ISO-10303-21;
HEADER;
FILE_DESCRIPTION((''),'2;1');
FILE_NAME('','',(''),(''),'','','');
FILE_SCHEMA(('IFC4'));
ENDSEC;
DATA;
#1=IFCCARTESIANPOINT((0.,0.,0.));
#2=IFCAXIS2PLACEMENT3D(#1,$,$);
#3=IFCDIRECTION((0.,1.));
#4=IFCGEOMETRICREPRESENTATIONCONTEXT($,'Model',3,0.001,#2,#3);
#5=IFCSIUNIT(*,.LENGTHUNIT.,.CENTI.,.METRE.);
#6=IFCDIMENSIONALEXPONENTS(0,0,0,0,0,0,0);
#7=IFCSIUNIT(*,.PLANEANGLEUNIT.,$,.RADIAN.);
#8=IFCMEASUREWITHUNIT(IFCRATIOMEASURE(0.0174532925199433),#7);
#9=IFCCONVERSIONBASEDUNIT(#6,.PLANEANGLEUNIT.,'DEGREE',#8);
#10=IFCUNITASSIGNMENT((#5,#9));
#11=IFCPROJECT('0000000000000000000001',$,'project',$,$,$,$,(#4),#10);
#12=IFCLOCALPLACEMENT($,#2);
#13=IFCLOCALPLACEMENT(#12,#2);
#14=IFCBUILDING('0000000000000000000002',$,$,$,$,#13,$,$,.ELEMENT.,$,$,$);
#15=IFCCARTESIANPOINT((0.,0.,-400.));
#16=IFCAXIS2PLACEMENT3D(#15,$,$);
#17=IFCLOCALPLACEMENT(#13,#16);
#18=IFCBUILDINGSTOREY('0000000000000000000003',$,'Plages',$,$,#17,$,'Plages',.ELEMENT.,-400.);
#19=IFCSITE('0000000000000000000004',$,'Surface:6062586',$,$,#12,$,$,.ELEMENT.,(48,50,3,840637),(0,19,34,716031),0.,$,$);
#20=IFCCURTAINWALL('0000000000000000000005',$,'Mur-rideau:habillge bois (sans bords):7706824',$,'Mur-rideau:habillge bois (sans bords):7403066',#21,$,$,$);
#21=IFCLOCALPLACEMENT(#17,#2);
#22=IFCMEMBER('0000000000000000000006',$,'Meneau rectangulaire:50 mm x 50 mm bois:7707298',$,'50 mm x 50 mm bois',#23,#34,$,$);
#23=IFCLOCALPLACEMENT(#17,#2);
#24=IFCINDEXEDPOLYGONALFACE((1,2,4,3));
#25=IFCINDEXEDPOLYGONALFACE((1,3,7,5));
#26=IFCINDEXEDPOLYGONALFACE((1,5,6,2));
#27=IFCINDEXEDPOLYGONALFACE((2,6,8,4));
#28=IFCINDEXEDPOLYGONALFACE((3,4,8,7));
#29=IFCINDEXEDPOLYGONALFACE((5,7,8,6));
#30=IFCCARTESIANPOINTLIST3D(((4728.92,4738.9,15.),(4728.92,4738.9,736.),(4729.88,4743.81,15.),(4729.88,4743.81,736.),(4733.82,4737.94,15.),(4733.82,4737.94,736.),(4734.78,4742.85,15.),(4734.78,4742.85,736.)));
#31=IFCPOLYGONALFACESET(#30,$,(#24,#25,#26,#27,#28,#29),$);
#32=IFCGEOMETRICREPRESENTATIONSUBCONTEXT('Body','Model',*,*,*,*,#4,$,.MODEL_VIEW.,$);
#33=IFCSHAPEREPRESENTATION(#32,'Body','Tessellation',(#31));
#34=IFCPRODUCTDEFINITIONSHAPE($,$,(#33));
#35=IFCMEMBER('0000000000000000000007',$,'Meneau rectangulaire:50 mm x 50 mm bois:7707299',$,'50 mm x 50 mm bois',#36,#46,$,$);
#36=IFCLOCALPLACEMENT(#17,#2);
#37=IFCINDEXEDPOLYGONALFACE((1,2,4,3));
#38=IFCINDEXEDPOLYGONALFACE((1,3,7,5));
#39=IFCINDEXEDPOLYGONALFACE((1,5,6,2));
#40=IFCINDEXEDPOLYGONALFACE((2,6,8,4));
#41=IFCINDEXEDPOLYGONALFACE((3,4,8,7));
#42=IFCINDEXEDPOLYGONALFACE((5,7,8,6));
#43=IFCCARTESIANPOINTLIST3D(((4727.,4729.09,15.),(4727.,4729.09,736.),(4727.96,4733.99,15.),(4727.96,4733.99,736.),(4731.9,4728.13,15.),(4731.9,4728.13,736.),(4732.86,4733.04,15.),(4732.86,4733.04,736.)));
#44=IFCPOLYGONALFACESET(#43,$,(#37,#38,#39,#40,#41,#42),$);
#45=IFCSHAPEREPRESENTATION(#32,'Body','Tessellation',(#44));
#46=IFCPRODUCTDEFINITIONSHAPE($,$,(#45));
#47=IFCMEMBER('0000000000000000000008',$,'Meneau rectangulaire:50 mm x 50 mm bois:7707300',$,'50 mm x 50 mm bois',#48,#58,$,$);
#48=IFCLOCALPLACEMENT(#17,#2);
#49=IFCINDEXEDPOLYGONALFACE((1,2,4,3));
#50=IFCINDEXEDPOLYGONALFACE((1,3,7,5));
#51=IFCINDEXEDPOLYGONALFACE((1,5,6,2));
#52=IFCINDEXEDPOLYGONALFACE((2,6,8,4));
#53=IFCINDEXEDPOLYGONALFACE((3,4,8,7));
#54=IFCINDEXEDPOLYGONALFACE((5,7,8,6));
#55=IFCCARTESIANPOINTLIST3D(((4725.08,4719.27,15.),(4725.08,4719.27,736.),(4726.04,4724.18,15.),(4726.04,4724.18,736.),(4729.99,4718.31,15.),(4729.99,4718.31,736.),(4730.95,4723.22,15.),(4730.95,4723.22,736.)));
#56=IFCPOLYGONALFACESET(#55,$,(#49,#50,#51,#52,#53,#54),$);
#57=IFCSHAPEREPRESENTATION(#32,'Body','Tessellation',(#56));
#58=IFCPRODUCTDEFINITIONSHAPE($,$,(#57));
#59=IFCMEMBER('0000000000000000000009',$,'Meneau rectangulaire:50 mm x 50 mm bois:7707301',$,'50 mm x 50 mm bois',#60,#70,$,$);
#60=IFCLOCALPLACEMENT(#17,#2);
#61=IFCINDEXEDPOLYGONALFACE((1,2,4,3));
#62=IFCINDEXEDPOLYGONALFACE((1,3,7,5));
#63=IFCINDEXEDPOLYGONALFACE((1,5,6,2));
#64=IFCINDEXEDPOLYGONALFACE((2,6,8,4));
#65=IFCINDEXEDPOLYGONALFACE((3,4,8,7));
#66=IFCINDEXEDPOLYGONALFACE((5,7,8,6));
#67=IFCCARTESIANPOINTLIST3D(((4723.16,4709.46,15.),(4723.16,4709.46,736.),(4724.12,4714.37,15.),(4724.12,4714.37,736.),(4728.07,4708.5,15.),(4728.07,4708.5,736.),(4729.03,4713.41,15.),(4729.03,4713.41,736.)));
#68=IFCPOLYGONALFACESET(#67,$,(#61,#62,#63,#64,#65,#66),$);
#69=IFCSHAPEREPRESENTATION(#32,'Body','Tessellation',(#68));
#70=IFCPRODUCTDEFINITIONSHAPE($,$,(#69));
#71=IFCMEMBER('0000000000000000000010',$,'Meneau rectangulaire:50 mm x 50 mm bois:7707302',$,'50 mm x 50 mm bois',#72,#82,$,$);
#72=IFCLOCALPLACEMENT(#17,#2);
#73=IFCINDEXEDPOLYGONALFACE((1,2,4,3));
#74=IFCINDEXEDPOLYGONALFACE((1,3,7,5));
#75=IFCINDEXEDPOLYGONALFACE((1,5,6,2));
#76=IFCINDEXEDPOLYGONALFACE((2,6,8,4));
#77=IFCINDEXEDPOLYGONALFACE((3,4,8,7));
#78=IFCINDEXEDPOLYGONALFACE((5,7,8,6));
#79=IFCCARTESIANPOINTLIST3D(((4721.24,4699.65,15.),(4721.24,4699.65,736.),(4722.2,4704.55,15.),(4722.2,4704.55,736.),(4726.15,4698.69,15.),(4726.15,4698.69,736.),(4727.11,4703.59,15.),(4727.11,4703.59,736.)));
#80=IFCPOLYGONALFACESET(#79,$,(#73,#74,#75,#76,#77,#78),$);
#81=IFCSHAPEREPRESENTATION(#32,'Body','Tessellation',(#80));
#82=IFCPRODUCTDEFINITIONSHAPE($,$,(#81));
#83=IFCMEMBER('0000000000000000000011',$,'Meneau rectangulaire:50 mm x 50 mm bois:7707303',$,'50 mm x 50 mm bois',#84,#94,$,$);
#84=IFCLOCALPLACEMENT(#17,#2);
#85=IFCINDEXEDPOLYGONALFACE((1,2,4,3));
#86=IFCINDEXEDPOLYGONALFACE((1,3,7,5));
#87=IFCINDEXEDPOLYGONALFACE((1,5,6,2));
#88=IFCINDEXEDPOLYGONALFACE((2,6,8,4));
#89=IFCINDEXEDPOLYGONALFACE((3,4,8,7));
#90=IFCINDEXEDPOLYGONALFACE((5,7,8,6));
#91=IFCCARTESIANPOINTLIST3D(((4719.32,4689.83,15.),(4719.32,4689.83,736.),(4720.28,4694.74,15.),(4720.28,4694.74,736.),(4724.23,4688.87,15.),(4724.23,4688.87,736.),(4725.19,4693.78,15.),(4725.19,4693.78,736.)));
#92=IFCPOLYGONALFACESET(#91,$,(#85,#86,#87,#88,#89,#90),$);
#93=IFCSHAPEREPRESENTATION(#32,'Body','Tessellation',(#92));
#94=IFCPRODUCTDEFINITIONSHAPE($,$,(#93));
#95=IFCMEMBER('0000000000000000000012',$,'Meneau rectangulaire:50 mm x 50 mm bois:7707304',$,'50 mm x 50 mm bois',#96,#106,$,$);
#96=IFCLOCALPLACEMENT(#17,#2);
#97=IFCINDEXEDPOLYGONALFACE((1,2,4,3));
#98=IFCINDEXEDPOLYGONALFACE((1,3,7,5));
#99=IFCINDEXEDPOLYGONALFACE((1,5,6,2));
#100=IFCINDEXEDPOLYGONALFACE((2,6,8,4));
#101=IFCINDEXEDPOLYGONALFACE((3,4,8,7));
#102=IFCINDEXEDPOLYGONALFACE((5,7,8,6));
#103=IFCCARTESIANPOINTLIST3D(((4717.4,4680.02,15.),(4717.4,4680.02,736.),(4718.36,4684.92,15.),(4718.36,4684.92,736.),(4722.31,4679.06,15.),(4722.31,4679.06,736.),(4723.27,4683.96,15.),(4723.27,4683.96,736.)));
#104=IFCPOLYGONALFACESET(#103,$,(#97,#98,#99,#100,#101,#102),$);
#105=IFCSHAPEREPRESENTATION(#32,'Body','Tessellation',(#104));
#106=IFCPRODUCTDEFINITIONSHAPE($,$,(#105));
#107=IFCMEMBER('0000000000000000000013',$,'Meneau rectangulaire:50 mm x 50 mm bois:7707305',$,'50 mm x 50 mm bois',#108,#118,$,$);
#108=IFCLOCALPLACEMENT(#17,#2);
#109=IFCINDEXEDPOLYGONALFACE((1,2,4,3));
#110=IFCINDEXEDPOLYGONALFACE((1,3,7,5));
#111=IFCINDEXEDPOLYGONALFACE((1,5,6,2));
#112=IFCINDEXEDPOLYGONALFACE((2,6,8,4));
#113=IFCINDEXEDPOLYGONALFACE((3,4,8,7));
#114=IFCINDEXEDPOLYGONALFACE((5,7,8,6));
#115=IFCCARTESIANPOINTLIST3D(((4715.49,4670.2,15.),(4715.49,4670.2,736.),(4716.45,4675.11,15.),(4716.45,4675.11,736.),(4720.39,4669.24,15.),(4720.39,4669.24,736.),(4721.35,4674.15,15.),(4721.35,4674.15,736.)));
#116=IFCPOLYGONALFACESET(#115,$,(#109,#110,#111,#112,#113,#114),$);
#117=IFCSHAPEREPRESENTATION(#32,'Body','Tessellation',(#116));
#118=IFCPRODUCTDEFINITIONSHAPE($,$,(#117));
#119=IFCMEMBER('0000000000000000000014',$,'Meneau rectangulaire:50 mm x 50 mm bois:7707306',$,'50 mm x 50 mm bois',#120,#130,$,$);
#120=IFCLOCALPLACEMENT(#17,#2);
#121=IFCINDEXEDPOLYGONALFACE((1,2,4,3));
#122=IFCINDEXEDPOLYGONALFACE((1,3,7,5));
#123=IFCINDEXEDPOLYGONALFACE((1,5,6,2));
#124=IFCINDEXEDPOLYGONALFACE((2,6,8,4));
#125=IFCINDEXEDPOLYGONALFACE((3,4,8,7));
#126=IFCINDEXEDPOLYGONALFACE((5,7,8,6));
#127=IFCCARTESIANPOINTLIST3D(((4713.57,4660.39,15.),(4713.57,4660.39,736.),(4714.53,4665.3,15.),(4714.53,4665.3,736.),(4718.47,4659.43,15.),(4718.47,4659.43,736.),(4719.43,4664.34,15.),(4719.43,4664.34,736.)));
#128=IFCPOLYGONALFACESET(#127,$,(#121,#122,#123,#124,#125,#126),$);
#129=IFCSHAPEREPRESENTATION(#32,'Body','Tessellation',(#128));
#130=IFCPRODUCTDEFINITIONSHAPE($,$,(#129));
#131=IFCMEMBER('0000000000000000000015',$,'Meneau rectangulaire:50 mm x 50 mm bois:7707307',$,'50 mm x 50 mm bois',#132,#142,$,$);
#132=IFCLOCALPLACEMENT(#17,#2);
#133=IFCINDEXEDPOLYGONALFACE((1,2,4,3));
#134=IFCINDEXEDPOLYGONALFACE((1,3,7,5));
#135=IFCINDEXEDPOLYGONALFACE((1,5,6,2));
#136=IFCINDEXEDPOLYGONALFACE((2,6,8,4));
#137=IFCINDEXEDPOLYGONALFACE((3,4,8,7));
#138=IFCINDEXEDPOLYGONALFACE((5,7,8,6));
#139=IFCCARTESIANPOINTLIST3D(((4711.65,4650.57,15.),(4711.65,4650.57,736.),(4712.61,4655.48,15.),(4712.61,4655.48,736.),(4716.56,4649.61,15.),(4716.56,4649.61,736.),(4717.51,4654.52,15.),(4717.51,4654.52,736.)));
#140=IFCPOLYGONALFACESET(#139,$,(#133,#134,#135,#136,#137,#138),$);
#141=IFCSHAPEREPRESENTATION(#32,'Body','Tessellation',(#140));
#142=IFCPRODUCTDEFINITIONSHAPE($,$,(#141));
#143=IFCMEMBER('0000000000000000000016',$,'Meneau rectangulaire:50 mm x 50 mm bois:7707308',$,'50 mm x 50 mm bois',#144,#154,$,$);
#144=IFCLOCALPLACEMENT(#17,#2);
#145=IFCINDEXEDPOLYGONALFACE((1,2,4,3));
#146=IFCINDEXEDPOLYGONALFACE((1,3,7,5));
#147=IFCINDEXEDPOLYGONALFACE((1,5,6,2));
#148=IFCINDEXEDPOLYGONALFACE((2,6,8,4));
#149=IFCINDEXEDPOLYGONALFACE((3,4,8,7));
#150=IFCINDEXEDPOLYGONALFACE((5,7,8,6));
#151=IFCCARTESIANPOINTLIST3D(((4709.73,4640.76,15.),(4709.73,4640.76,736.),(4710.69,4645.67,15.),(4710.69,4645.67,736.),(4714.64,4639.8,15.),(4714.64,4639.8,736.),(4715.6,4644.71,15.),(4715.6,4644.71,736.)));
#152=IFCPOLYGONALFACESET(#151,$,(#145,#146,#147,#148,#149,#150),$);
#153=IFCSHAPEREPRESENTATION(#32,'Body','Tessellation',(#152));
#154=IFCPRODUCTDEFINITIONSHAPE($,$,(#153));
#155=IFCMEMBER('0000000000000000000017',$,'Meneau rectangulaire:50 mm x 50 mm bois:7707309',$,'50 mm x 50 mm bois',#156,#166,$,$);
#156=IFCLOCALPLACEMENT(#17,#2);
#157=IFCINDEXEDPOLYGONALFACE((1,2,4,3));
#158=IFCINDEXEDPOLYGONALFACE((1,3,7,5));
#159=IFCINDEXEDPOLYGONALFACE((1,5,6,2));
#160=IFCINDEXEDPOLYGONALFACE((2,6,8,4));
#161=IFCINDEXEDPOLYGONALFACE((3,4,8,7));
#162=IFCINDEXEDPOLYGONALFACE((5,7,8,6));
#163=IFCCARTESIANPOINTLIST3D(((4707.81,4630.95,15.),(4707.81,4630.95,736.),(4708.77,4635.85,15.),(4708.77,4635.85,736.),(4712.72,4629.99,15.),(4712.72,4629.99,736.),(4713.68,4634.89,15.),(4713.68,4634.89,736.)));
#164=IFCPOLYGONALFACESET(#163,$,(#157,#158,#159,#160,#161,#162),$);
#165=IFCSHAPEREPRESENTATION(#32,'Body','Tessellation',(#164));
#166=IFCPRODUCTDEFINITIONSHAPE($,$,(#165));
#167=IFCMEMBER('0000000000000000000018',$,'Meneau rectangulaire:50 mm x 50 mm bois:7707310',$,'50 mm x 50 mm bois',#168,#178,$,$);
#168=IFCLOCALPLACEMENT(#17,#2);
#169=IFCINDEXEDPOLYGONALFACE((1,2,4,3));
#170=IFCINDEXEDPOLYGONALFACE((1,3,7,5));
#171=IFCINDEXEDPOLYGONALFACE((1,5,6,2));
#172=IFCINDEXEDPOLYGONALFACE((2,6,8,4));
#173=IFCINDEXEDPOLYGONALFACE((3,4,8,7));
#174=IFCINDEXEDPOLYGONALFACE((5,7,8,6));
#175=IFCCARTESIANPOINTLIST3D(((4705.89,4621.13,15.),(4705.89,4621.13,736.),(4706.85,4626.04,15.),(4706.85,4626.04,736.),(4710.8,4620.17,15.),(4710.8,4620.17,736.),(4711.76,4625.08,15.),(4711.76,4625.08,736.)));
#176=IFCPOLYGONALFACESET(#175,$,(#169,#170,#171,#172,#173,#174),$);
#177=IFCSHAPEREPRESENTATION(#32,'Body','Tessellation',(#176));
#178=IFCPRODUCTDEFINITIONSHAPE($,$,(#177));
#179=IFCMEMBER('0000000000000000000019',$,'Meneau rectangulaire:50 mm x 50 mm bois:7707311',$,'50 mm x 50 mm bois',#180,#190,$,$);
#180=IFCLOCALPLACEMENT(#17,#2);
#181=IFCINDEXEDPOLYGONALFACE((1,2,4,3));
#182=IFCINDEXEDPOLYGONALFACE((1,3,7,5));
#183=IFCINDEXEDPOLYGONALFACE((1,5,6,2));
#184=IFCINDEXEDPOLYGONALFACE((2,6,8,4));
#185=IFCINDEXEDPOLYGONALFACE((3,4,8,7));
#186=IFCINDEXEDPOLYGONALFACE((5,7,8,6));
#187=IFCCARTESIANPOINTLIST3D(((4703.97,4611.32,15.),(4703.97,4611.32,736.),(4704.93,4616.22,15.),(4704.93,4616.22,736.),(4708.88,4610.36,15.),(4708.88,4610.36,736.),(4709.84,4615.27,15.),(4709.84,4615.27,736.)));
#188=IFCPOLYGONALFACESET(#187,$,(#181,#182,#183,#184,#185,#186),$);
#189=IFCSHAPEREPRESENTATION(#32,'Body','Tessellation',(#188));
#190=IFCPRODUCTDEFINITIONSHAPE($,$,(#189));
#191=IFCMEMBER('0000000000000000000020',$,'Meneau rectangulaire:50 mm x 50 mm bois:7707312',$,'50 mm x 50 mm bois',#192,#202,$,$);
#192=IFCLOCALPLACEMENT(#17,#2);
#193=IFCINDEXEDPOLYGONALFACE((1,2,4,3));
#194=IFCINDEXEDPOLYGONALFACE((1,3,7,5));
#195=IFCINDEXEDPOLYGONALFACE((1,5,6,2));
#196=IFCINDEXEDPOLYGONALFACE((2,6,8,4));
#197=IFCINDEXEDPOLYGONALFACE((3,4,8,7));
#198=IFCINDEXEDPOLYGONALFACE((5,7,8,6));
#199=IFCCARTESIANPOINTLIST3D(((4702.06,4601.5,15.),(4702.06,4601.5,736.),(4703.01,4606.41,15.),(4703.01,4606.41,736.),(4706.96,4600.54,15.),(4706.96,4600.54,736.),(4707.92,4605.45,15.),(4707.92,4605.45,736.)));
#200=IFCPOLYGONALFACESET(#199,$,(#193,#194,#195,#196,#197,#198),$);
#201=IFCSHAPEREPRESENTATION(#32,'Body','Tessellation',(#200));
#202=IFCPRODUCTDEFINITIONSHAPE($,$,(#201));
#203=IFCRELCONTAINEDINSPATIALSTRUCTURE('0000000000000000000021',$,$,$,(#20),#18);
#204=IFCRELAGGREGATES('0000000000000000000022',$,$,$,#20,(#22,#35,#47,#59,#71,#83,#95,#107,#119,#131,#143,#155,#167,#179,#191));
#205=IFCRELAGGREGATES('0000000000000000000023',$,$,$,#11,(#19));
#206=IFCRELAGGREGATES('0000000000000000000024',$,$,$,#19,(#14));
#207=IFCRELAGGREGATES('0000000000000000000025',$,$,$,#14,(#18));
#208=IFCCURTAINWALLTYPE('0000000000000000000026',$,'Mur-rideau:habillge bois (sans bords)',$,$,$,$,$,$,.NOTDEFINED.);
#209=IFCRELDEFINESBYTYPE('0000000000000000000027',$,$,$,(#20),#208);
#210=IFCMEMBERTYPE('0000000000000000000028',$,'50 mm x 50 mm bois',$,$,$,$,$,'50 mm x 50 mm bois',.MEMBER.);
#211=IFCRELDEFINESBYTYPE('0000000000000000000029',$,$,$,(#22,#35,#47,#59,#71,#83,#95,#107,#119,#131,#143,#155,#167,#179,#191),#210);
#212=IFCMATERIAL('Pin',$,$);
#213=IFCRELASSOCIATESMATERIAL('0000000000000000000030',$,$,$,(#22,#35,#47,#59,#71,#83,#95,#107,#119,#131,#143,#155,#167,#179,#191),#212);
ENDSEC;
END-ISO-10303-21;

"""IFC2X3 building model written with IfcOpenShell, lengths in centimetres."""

from ifc_helpers import new_model, entity, si_unit, converted_unit, direction, frame, origin, origin_2d_with_axis, place, context, subcontext, project, spatial, rectangle, extrude, source, transform, mapped, material, type_object, type_shapes, element, aggregate, save


model = new_model("IFC2X3")

# Units and contexts
model_context = context("Model", 3, precision=0.001, world=origin(), true_north=direction((0.0, 1.0)))
body_context = subcontext(model_context, "Body", "Model", "MODEL_VIEW")
ifc_project = project(units=[si_unit("LENGTHUNIT", "METRE", prefix="CENTI"), converted_unit("PLANEANGLEUNIT", "DEGREE", entity("IfcRatioMeasure", 0.0174532925199433), si_unit("PLANEANGLEUNIT", "RADIAN"), dimensions=[0, 0, 0, 0, 0, 0, 0])], contexts=[model_context])

# Site, building, storey
site_placement = place(None, origin())
site = spatial("IfcSite", under=ifc_project, at=site_placement, Name="Surface:6062586", CompositionType="ELEMENT", RefLatitude=(48, 50, 3, 840637), RefLongitude=(0, 19, 34, 716031), RefElevation=0.0)
building_placement = place(site_placement, origin())
building = spatial("IfcBuilding", under=site, at=building_placement, CompositionType="ELEMENT")
storey_placement = place(building_placement, frame((0.0, 0.0, -400.0)))
storey = spatial("IfcBuildingStorey", under=building, at=storey_placement, Name="Plages", LongName="Plages", CompositionType="ELEMENT", Elevation=-400.0)

# Curtain wall, members
curtain_wall_type = type_object("IfcCurtainWallType", Name="Mur-rideau:habillge bois (sans bords)", PredefinedType="NOTDEFINED")
curtain_wall_placement = place(storey_placement, frame((0.0, 0.0, 400.0)))
curtain_wall = element("IfcCurtainWall", 1, at=curtain_wall_placement, inside=storey, type_object=curtain_wall_type, Name="Mur-rideau:habillge bois (sans bords):7706824", ObjectType="Mur-rideau:habillge bois (sans bords):7403066")
ifc_material = material(Name="Pin")
member_type = type_object("IfcMemberType", Name="50 mm x 50 mm bois", ElementType="50 mm x 50 mm bois", PredefinedType="MEMBER")
shared_shape = source(origin(), body_context, "Body", "SweptSolid", [
    extrude(rectangle(XDim=5.0, YDim=5.0, at=origin_2d_with_axis()), frame((0.0, 0.0, -721.0), z_axis=(0.0, 0.0, 1.0), x_axis=(0.0, -1.0, 0.0)), (0.0, 0.0, 1.0), 721.0),
])
type_shapes(member_type, [shared_shape])
placement = place(building_placement, frame((0.0, 0.0, 336.0)))
member_1_placement = place(placement, frame((4731.85, 4740.88, -721.0), z_axis=(0.0, 0.0, -1.0), x_axis=(0.191861, 0.981422, 0.0)))
member_1 = element("IfcMember", 2, at=member_1_placement, type_object=member_type, material=ifc_material, Name="Meneau rectangulaire:50 mm x 50 mm bois:7707298", ObjectType="50 mm x 50 mm bois", context=body_context, shape_type="MappedRepresentation", body=[
    mapped(shared_shape, transform((0.0, 0.0, 0.0), scale=1.0)),
])
member_2_placement = place(placement, frame((4729.93, 4731.06, -721.0), z_axis=(0.0, 0.0, -1.0), x_axis=(0.191861, 0.981422, 0.0)))
member_2 = element("IfcMember", 3, at=member_2_placement, type_object=member_type, material=ifc_material, Name="Meneau rectangulaire:50 mm x 50 mm bois:7707299", ObjectType="50 mm x 50 mm bois", context=body_context, shape_type="MappedRepresentation", body=[
    mapped(shared_shape, transform((0.0, 0.0, 0.0), scale=1.0)),
])
member_3_placement = place(placement, frame((4728.01, 4721.25, -721.0), z_axis=(0.0, 0.0, -1.0), x_axis=(0.191861, 0.981422, 0.0)))
member_3 = element("IfcMember", 4, at=member_3_placement, type_object=member_type, material=ifc_material, Name="Meneau rectangulaire:50 mm x 50 mm bois:7707300", ObjectType="50 mm x 50 mm bois", context=body_context, shape_type="MappedRepresentation", body=[
    mapped(shared_shape, transform((0.0, 0.0, 0.0), scale=1.0)),
])
member_4_placement = place(placement, frame((4726.09, 4711.43, -721.0), z_axis=(0.0, 0.0, -1.0), x_axis=(0.191861, 0.981422, 0.0)))
member_4 = element("IfcMember", 5, at=member_4_placement, type_object=member_type, material=ifc_material, Name="Meneau rectangulaire:50 mm x 50 mm bois:7707301", ObjectType="50 mm x 50 mm bois", context=body_context, shape_type="MappedRepresentation", body=[
    mapped(shared_shape, transform((0.0, 0.0, 0.0), scale=1.0)),
])
member_5_placement = place(placement, frame((4724.17, 4701.62, -721.0), z_axis=(0.0, 0.0, -1.0), x_axis=(0.191861, 0.981422, 0.0)))
member_5 = element("IfcMember", 6, at=member_5_placement, type_object=member_type, material=ifc_material, Name="Meneau rectangulaire:50 mm x 50 mm bois:7707302", ObjectType="50 mm x 50 mm bois", context=body_context, shape_type="MappedRepresentation", body=[
    mapped(shared_shape, transform((0.0, 0.0, 0.0), scale=1.0)),
])
member_6_placement = place(placement, frame((4722.26, 4691.8, -721.0), z_axis=(0.0, 0.0, -1.0), x_axis=(0.191861, 0.981422, 0.0)))
member_6 = element("IfcMember", 7, at=member_6_placement, type_object=member_type, material=ifc_material, Name="Meneau rectangulaire:50 mm x 50 mm bois:7707303", ObjectType="50 mm x 50 mm bois", context=body_context, shape_type="MappedRepresentation", body=[
    mapped(shared_shape, transform((0.0, 0.0, 0.0), scale=1.0)),
])
member_7_placement = place(placement, frame((4720.34, 4681.99, -721.0), z_axis=(0.0, 0.0, -1.0), x_axis=(0.191861, 0.981422, 0.0)))
member_7 = element("IfcMember", 8, at=member_7_placement, type_object=member_type, material=ifc_material, Name="Meneau rectangulaire:50 mm x 50 mm bois:7707304", ObjectType="50 mm x 50 mm bois", context=body_context, shape_type="MappedRepresentation", body=[
    mapped(shared_shape, transform((0.0, 0.0, 0.0), scale=1.0)),
])
member_8_placement = place(placement, frame((4718.42, 4672.18, -721.0), z_axis=(0.0, 0.0, -1.0), x_axis=(0.191861, 0.981422, 0.0)))
member_8 = element("IfcMember", 9, at=member_8_placement, type_object=member_type, material=ifc_material, Name="Meneau rectangulaire:50 mm x 50 mm bois:7707305", ObjectType="50 mm x 50 mm bois", context=body_context, shape_type="MappedRepresentation", body=[
    mapped(shared_shape, transform((0.0, 0.0, 0.0), scale=1.0)),
])
member_9_placement = place(placement, frame((4716.5, 4662.36, -721.0), z_axis=(0.0, 0.0, -1.0), x_axis=(0.191861, 0.981422, 0.0)))
member_9 = element("IfcMember", 10, at=member_9_placement, type_object=member_type, material=ifc_material, Name="Meneau rectangulaire:50 mm x 50 mm bois:7707306", ObjectType="50 mm x 50 mm bois", context=body_context, shape_type="MappedRepresentation", body=[
    mapped(shared_shape, transform((0.0, 0.0, 0.0), scale=1.0)),
])
member_10_placement = place(placement, frame((4714.58, 4652.55, -721.0), z_axis=(0.0, 0.0, -1.0), x_axis=(0.191861, 0.981422, 0.0)))
member_10 = element("IfcMember", 11, at=member_10_placement, type_object=member_type, material=ifc_material, Name="Meneau rectangulaire:50 mm x 50 mm bois:7707307", ObjectType="50 mm x 50 mm bois", context=body_context, shape_type="MappedRepresentation", body=[
    mapped(shared_shape, transform((0.0, 0.0, 0.0), scale=1.0)),
])
member_11_placement = place(placement, frame((4712.66, 4642.73, -721.0), z_axis=(0.0, 0.0, -1.0), x_axis=(0.191861, 0.981422, 0.0)))
member_11 = element("IfcMember", 12, at=member_11_placement, type_object=member_type, material=ifc_material, Name="Meneau rectangulaire:50 mm x 50 mm bois:7707308", ObjectType="50 mm x 50 mm bois", context=body_context, shape_type="MappedRepresentation", body=[
    mapped(shared_shape, transform((0.0, 0.0, 0.0), scale=1.0)),
])
member_12_placement = place(placement, frame((4710.74, 4632.92, -721.0), z_axis=(0.0, 0.0, -1.0), x_axis=(0.191861, 0.981422, 0.0)))
member_12 = element("IfcMember", 13, at=member_12_placement, type_object=member_type, material=ifc_material, Name="Meneau rectangulaire:50 mm x 50 mm bois:7707309", ObjectType="50 mm x 50 mm bois", context=body_context, shape_type="MappedRepresentation", body=[
    mapped(shared_shape, transform((0.0, 0.0, 0.0), scale=1.0)),
])
member_13_placement = place(placement, frame((4708.83, 4623.11, -721.0), z_axis=(0.0, 0.0, -1.0), x_axis=(0.191861, 0.981422, 0.0)))
member_13 = element("IfcMember", 14, at=member_13_placement, type_object=member_type, material=ifc_material, Name="Meneau rectangulaire:50 mm x 50 mm bois:7707310", ObjectType="50 mm x 50 mm bois", context=body_context, shape_type="MappedRepresentation", body=[
    mapped(shared_shape, transform((0.0, 0.0, 0.0), scale=1.0)),
])
member_14_placement = place(placement, frame((4706.91, 4613.29, -721.0), z_axis=(0.0, 0.0, -1.0), x_axis=(0.191861, 0.981422, 0.0)))
member_14 = element("IfcMember", 15, at=member_14_placement, type_object=member_type, material=ifc_material, Name="Meneau rectangulaire:50 mm x 50 mm bois:7707311", ObjectType="50 mm x 50 mm bois", context=body_context, shape_type="MappedRepresentation", body=[
    mapped(shared_shape, transform((0.0, 0.0, 0.0), scale=1.0)),
])
member_15_placement = place(placement, frame((4704.99, 4603.48, -721.0), z_axis=(0.0, 0.0, -1.0), x_axis=(0.191861, 0.981422, 0.0)))
member_15 = element("IfcMember", 16, at=member_15_placement, type_object=member_type, material=ifc_material, Name="Meneau rectangulaire:50 mm x 50 mm bois:7707312", ObjectType="50 mm x 50 mm bois", context=body_context, shape_type="MappedRepresentation", body=[
    mapped(shared_shape, transform((0.0, 0.0, 0.0), scale=1.0)),
])
aggregate(curtain_wall, [member_1, member_2, member_3, member_4, member_5, member_6, member_7, member_8, member_9, member_10, member_11, member_12, member_13, member_14, member_15])

save(model, "model.ifc")
